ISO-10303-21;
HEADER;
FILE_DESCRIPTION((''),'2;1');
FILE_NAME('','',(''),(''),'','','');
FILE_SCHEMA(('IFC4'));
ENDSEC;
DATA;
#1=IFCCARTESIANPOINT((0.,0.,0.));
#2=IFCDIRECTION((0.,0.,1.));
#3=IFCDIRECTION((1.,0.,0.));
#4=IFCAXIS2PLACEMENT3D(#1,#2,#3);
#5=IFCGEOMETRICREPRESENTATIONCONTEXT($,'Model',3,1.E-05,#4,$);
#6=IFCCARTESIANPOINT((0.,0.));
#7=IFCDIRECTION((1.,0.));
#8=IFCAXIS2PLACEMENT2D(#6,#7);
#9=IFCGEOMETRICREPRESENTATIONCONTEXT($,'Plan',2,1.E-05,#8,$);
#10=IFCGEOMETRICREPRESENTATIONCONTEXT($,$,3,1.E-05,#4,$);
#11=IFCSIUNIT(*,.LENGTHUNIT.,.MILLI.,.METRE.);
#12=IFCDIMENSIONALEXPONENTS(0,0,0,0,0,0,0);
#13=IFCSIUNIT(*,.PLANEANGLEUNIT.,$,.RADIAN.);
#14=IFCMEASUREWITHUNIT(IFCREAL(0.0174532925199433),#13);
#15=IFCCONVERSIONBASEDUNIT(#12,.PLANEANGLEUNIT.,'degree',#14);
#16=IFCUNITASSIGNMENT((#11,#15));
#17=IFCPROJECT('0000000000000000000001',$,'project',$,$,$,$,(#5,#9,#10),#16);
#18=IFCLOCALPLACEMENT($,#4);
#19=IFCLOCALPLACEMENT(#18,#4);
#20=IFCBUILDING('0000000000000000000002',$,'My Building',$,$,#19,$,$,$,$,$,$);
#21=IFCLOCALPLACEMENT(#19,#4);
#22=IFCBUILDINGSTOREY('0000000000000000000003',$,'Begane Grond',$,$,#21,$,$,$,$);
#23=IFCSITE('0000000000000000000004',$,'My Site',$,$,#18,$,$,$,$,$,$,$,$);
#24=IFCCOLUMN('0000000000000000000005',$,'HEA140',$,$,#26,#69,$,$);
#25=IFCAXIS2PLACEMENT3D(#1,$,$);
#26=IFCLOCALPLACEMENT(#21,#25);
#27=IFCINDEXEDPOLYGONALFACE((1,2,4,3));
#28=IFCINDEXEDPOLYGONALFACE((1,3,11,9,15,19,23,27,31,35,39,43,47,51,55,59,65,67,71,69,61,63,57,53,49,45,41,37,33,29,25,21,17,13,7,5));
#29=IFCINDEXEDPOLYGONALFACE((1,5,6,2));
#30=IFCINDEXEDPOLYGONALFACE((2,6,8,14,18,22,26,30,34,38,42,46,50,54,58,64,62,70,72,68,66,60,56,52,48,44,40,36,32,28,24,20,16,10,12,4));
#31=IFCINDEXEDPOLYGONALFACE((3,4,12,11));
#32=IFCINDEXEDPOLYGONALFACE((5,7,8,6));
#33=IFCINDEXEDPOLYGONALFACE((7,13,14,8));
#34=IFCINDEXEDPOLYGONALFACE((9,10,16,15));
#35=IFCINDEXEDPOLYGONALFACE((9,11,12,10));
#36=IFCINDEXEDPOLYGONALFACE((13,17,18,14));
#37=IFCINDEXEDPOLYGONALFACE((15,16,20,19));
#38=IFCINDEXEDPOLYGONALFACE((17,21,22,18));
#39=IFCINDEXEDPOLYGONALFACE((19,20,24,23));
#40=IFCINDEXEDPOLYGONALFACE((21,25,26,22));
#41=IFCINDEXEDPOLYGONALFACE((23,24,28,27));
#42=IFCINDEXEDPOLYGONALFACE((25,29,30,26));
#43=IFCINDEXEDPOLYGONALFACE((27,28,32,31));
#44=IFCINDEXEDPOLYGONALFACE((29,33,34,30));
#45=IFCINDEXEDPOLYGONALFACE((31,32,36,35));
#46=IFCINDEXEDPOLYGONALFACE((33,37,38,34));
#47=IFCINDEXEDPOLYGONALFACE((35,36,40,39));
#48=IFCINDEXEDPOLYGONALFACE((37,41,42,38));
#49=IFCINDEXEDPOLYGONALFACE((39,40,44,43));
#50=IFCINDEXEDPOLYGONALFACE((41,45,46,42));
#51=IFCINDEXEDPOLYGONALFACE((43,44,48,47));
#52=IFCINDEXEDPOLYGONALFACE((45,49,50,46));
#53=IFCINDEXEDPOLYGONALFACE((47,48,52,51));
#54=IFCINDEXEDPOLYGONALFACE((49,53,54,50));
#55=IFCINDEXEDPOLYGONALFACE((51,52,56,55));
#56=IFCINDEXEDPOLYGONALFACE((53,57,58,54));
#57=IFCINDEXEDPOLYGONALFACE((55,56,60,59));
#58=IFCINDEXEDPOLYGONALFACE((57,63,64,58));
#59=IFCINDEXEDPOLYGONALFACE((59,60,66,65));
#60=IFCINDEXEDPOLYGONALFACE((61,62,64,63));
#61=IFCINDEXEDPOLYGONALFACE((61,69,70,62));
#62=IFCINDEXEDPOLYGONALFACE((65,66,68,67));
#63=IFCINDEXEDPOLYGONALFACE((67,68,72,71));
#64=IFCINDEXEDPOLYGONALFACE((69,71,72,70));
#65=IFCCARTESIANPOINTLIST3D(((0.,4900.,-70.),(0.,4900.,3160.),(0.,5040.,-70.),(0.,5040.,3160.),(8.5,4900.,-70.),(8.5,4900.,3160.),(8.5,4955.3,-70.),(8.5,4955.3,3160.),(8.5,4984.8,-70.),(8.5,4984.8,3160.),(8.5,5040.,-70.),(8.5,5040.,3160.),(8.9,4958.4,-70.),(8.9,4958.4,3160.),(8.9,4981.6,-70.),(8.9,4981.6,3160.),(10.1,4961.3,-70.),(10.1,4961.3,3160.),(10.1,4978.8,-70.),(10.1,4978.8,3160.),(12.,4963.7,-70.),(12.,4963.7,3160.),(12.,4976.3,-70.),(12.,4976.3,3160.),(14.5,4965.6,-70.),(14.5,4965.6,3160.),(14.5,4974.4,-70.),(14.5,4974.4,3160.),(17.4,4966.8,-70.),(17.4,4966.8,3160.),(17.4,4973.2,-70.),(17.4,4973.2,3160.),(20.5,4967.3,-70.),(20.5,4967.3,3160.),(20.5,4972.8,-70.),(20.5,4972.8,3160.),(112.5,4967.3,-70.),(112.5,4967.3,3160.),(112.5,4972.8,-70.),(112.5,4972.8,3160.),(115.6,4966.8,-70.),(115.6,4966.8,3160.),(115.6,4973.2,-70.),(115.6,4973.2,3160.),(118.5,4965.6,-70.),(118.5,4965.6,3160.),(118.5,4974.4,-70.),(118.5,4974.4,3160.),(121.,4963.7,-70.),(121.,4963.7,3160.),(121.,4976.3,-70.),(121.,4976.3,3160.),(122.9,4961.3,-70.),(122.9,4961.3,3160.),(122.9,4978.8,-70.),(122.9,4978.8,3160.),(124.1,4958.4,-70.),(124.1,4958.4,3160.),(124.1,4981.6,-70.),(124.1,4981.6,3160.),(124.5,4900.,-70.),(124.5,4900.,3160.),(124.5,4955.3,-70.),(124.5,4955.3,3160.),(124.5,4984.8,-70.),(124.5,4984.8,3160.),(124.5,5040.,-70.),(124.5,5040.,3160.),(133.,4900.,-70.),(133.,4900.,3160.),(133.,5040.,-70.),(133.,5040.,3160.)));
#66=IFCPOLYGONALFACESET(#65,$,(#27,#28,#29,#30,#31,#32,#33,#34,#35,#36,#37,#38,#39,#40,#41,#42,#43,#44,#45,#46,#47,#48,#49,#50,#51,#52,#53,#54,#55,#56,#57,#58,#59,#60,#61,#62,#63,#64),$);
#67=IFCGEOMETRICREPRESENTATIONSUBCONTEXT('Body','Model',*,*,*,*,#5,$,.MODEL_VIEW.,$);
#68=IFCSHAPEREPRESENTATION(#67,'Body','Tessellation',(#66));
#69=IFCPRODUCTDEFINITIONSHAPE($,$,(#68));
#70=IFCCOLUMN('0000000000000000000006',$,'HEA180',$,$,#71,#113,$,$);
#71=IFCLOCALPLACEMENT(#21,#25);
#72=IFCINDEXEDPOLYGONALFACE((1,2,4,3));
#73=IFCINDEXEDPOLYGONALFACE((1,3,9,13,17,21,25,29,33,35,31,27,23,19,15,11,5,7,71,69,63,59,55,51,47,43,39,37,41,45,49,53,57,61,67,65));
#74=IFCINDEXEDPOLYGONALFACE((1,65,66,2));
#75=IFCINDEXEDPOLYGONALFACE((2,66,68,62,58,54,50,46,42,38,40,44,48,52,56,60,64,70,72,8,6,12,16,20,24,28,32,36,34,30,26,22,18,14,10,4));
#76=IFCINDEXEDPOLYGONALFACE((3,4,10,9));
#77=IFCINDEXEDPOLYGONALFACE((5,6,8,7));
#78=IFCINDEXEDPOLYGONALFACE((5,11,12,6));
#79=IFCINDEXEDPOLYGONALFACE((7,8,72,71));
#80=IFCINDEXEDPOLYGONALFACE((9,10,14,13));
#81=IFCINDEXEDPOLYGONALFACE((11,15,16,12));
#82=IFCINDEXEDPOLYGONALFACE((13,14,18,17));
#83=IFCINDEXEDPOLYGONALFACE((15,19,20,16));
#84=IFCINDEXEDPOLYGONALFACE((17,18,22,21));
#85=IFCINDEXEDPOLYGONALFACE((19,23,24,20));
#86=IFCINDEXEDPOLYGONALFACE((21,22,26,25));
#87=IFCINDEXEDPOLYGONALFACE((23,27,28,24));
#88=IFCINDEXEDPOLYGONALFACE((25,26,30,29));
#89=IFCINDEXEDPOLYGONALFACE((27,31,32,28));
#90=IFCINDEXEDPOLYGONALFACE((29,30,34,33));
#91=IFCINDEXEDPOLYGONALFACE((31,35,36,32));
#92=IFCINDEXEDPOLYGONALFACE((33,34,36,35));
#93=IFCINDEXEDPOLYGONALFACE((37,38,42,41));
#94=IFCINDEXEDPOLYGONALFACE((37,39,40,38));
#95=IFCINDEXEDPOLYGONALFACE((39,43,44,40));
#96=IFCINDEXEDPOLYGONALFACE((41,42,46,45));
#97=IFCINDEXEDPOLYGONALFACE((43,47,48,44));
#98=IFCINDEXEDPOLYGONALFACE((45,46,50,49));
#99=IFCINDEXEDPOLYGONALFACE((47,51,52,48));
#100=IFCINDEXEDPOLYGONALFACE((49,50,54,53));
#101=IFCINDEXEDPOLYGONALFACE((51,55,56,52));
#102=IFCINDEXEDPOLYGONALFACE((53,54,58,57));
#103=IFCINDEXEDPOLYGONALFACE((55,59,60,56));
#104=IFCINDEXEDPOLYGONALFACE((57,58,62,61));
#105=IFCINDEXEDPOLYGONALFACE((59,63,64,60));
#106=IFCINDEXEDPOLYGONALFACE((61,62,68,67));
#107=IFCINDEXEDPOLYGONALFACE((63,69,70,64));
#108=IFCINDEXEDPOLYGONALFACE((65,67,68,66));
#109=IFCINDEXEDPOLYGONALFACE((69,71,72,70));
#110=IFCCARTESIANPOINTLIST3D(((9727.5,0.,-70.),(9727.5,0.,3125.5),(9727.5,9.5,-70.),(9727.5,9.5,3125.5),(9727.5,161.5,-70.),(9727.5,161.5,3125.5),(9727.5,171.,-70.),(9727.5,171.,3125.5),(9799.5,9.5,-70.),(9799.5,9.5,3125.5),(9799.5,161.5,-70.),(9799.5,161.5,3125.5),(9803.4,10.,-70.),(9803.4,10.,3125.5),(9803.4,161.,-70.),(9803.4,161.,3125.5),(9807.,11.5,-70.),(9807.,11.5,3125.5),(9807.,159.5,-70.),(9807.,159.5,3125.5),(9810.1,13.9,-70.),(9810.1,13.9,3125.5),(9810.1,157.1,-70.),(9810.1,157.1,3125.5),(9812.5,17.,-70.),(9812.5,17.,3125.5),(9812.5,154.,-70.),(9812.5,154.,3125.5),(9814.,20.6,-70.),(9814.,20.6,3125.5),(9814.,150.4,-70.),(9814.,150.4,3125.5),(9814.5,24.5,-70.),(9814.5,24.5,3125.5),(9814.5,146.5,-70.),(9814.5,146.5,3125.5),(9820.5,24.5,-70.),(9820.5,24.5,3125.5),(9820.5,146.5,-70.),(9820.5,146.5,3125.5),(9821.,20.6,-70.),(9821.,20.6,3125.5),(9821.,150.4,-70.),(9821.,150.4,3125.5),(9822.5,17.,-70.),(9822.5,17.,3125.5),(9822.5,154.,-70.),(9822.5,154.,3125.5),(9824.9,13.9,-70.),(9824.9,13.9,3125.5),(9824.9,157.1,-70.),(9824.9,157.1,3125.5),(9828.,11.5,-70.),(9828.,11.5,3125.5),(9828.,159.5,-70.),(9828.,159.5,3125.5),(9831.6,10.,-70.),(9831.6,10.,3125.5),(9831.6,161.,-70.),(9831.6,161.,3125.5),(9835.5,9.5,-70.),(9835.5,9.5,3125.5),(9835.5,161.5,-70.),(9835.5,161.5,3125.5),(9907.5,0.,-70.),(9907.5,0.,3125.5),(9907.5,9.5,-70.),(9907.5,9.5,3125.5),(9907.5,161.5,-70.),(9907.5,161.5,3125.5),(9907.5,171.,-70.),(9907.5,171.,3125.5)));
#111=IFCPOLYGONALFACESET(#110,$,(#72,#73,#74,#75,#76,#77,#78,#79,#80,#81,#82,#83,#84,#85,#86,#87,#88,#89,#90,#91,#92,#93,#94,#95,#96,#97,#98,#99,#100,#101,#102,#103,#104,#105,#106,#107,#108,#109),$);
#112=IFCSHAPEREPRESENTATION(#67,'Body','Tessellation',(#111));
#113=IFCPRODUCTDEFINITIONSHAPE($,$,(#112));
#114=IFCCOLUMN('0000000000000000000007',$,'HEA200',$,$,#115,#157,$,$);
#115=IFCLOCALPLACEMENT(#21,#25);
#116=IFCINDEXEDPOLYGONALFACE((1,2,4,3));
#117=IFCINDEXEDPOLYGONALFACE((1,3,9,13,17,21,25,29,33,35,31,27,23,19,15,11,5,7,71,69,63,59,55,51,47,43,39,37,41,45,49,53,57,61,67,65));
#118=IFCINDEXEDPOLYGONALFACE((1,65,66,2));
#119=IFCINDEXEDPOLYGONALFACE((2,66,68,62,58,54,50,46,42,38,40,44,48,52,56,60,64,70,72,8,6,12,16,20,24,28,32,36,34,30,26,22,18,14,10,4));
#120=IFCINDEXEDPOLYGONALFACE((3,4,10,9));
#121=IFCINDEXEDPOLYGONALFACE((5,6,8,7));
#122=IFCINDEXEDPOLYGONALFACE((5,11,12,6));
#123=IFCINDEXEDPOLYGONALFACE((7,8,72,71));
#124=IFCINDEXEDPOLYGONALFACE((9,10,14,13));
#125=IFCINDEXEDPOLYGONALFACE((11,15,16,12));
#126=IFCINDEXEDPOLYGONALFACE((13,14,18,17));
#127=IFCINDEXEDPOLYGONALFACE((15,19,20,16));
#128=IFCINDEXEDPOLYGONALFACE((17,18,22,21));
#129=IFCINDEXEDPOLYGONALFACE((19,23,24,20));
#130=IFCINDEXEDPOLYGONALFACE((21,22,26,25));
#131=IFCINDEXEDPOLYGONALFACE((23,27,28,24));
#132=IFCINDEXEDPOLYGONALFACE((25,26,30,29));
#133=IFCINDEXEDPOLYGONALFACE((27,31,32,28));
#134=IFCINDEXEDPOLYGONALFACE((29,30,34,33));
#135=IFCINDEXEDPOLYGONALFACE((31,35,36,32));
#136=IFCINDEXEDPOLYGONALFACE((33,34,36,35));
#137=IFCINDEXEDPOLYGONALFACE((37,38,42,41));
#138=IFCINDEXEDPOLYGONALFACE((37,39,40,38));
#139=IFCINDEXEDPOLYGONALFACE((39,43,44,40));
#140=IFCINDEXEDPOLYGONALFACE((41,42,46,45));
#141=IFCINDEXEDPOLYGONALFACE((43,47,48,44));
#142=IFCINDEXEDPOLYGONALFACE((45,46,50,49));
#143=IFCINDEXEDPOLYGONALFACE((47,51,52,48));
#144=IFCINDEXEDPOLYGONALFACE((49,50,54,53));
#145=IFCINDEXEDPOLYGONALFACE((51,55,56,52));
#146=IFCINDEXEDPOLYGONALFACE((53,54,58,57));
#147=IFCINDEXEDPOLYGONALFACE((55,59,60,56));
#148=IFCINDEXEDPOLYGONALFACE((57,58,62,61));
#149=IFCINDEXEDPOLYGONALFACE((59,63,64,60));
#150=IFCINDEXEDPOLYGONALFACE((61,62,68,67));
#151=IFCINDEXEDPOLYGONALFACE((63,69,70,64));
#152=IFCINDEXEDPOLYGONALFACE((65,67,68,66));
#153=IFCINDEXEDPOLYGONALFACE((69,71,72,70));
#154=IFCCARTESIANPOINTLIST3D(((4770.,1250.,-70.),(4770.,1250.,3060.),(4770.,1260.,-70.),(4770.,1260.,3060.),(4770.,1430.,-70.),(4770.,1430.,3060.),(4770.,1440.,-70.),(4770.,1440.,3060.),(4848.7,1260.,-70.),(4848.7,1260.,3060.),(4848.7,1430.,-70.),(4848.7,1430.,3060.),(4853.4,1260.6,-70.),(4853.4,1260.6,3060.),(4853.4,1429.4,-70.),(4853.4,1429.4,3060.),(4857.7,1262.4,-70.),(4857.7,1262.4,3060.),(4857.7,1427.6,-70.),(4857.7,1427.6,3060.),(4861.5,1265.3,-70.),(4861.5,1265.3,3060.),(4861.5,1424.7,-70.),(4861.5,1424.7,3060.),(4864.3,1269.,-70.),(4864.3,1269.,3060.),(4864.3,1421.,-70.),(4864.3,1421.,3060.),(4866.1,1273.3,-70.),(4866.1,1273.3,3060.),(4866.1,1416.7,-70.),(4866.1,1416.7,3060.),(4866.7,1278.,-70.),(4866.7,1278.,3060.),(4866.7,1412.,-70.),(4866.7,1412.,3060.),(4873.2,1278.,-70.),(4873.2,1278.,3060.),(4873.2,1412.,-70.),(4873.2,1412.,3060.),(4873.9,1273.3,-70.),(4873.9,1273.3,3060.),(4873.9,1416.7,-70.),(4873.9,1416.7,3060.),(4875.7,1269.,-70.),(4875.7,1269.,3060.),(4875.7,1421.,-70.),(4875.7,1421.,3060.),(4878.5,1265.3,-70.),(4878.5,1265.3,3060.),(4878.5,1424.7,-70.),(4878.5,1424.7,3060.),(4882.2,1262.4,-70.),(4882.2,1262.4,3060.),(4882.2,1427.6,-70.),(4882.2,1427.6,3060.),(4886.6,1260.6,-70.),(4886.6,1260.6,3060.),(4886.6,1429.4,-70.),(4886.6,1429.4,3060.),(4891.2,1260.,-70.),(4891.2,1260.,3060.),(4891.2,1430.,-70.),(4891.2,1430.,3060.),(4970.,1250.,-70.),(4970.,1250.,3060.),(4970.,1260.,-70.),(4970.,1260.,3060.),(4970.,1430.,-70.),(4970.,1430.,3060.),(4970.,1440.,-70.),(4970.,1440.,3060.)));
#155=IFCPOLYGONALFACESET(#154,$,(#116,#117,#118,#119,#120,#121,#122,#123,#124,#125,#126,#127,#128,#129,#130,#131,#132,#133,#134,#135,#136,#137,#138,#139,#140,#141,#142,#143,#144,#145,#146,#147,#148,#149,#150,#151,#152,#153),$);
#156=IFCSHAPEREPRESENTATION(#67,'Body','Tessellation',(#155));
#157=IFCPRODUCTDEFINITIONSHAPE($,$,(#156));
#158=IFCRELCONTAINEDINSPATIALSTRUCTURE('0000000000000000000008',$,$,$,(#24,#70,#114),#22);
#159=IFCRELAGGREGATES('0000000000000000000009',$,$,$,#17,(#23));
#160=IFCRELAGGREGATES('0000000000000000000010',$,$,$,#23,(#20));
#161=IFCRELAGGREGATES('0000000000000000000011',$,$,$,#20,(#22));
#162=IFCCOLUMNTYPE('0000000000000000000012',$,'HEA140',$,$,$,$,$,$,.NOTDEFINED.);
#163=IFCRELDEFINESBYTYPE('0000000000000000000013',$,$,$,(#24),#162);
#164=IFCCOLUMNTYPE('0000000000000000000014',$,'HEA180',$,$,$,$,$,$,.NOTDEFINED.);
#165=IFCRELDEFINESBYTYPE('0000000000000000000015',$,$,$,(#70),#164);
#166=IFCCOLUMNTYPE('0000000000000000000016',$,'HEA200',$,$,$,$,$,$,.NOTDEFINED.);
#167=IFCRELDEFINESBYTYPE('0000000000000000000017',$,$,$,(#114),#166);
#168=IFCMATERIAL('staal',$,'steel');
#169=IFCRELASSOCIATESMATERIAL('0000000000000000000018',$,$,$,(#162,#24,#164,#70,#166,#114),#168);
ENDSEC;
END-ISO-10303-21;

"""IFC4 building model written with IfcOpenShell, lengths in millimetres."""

from ifc_helpers import new_model, entity, si_unit, converted_unit, frame, origin_with_axes, origin_2d_with_axis, place, context, subcontext, project, spatial, i_section, extrude, material, material_profile, profile_set, profile_usage, type_object, element, save


model = new_model("IFC4")

# Units and contexts
model_context = context("Model", 3, precision=1e-05, world=origin_with_axes())
plan_context = context("Plan", 2, precision=1e-05, world=origin_2d_with_axis())
context_of_model = context(None, 3, precision=1e-05, world=origin_with_axes())
body_context = subcontext(model_context, "Body", "Model", "MODEL_VIEW")
ifc_project = project(units=[si_unit("LENGTHUNIT", "METRE", prefix="MILLI"), converted_unit("PLANEANGLEUNIT", "degree", entity("IfcReal", 0.0174532925199433), si_unit("PLANEANGLEUNIT", "RADIAN"), dimensions=[0, 0, 0, 0, 0, 0, 0])], contexts=[model_context, plan_context, context_of_model])

# Site, building, storey
site_placement = place(None, origin_with_axes())
site = spatial("IfcSite", under=ifc_project, at=site_placement, Name="My Site")
building_placement = place(site_placement, origin_with_axes())
building = spatial("IfcBuilding", under=site, at=building_placement, Name="My Building")
storey_placement = place(building_placement, origin_with_axes())
storey = spatial("IfcBuildingStorey", under=building, at=storey_placement, Name="Begane Grond")

# Columns
ifc_material = material(Name="staal", Category="steel")
ifc_material_profile_1 = material_profile(ifc_material, i_section(OverallWidth=140.0, OverallDepth=133.0, WebThickness=5.5, FlangeThickness=8.5, FilletRadius=12.0))
ifc_profile_set_1 = profile_set([ifc_material_profile_1], Name="HEA140")
column_type_1 = type_object("IfcColumnType", Name="HEA140", PredefinedType="NOTDEFINED", material=ifc_profile_set_1)
for number, where, z_axis, x_axis, name in (
    (1, (66.5, 4970.0, -70.0), (0.0, 0.0, 1.0), (0.0, 1.0, 0.0), "HEA140"),
):
    element("IfcColumn", number, at=place(storey_placement, frame(where, z_axis=z_axis, x_axis=x_axis)), inside=storey, type_object=column_type_1, material=ifc_material, Name=name, context=body_context, shape_type="SweptSolid", body=[
        extrude(i_section(OverallWidth=140.0, OverallDepth=133.0, WebThickness=5.5, FlangeThickness=8.5, FilletRadius=12.0), origin_with_axes(), (0.0, 0.0, 1.0), 3230.0),
    ])
ifc_material_profile_2 = material_profile(ifc_material, i_section(OverallWidth=180.0, OverallDepth=171.0, WebThickness=6.0, FlangeThickness=9.5, FilletRadius=15.0))
ifc_profile_set_2 = profile_set([ifc_material_profile_2], Name="HEA180")
ifc_profile_usage_1 = profile_usage(ifc_profile_set_2)
column_type_2 = type_object("IfcColumnType", Name="HEA180", PredefinedType="NOTDEFINED", material=ifc_profile_set_2)
column_1_placement = place(storey_placement, frame((9817.5, 85.5, -70.0), z_axis=(0.0, 0.0, 1.0), x_axis=(-1.0, 0.0, 0.0)))
element("IfcColumn", 2, at=column_1_placement, inside=storey, type_object=column_type_2, material=ifc_profile_usage_1, Name="HEA180", context=body_context, shape_type="SweptSolid", body=[
    extrude(i_section(OverallWidth=180.0, OverallDepth=171.0, WebThickness=6.0, FlangeThickness=9.5, FilletRadius=15.0), origin_with_axes(), (0.0, 0.0, 1.0), 3195.5),
])
ifc_material_profile_3 = material_profile(ifc_material, i_section(OverallWidth=200.0, OverallDepth=190.0, WebThickness=6.5, FlangeThickness=10.0, FilletRadius=18.0))
ifc_profile_set_3 = profile_set([ifc_material_profile_3], Name="HEA200")
ifc_profile_usage_2 = profile_usage(ifc_profile_set_3)
column_type_3 = type_object("IfcColumnType", Name="HEA200", PredefinedType="NOTDEFINED", material=ifc_profile_set_3)
column_2_placement = place(storey_placement, frame((4870.0, 1345.0, -70.0), z_axis=(0.0, 0.0, 1.0), x_axis=(-1.0, 0.0, 0.0)))
element("IfcColumn", 3, at=column_2_placement, inside=storey, type_object=column_type_3, material=ifc_profile_usage_2, Name="HEA200", context=body_context, shape_type="SweptSolid", body=[
    extrude(i_section(OverallWidth=200.0, OverallDepth=190.0, WebThickness=6.5, FlangeThickness=10.0, FilletRadius=18.0), origin_with_axes(), (0.0, 0.0, 1.0), 3130.0),
])

save(model, "model.ifc")
